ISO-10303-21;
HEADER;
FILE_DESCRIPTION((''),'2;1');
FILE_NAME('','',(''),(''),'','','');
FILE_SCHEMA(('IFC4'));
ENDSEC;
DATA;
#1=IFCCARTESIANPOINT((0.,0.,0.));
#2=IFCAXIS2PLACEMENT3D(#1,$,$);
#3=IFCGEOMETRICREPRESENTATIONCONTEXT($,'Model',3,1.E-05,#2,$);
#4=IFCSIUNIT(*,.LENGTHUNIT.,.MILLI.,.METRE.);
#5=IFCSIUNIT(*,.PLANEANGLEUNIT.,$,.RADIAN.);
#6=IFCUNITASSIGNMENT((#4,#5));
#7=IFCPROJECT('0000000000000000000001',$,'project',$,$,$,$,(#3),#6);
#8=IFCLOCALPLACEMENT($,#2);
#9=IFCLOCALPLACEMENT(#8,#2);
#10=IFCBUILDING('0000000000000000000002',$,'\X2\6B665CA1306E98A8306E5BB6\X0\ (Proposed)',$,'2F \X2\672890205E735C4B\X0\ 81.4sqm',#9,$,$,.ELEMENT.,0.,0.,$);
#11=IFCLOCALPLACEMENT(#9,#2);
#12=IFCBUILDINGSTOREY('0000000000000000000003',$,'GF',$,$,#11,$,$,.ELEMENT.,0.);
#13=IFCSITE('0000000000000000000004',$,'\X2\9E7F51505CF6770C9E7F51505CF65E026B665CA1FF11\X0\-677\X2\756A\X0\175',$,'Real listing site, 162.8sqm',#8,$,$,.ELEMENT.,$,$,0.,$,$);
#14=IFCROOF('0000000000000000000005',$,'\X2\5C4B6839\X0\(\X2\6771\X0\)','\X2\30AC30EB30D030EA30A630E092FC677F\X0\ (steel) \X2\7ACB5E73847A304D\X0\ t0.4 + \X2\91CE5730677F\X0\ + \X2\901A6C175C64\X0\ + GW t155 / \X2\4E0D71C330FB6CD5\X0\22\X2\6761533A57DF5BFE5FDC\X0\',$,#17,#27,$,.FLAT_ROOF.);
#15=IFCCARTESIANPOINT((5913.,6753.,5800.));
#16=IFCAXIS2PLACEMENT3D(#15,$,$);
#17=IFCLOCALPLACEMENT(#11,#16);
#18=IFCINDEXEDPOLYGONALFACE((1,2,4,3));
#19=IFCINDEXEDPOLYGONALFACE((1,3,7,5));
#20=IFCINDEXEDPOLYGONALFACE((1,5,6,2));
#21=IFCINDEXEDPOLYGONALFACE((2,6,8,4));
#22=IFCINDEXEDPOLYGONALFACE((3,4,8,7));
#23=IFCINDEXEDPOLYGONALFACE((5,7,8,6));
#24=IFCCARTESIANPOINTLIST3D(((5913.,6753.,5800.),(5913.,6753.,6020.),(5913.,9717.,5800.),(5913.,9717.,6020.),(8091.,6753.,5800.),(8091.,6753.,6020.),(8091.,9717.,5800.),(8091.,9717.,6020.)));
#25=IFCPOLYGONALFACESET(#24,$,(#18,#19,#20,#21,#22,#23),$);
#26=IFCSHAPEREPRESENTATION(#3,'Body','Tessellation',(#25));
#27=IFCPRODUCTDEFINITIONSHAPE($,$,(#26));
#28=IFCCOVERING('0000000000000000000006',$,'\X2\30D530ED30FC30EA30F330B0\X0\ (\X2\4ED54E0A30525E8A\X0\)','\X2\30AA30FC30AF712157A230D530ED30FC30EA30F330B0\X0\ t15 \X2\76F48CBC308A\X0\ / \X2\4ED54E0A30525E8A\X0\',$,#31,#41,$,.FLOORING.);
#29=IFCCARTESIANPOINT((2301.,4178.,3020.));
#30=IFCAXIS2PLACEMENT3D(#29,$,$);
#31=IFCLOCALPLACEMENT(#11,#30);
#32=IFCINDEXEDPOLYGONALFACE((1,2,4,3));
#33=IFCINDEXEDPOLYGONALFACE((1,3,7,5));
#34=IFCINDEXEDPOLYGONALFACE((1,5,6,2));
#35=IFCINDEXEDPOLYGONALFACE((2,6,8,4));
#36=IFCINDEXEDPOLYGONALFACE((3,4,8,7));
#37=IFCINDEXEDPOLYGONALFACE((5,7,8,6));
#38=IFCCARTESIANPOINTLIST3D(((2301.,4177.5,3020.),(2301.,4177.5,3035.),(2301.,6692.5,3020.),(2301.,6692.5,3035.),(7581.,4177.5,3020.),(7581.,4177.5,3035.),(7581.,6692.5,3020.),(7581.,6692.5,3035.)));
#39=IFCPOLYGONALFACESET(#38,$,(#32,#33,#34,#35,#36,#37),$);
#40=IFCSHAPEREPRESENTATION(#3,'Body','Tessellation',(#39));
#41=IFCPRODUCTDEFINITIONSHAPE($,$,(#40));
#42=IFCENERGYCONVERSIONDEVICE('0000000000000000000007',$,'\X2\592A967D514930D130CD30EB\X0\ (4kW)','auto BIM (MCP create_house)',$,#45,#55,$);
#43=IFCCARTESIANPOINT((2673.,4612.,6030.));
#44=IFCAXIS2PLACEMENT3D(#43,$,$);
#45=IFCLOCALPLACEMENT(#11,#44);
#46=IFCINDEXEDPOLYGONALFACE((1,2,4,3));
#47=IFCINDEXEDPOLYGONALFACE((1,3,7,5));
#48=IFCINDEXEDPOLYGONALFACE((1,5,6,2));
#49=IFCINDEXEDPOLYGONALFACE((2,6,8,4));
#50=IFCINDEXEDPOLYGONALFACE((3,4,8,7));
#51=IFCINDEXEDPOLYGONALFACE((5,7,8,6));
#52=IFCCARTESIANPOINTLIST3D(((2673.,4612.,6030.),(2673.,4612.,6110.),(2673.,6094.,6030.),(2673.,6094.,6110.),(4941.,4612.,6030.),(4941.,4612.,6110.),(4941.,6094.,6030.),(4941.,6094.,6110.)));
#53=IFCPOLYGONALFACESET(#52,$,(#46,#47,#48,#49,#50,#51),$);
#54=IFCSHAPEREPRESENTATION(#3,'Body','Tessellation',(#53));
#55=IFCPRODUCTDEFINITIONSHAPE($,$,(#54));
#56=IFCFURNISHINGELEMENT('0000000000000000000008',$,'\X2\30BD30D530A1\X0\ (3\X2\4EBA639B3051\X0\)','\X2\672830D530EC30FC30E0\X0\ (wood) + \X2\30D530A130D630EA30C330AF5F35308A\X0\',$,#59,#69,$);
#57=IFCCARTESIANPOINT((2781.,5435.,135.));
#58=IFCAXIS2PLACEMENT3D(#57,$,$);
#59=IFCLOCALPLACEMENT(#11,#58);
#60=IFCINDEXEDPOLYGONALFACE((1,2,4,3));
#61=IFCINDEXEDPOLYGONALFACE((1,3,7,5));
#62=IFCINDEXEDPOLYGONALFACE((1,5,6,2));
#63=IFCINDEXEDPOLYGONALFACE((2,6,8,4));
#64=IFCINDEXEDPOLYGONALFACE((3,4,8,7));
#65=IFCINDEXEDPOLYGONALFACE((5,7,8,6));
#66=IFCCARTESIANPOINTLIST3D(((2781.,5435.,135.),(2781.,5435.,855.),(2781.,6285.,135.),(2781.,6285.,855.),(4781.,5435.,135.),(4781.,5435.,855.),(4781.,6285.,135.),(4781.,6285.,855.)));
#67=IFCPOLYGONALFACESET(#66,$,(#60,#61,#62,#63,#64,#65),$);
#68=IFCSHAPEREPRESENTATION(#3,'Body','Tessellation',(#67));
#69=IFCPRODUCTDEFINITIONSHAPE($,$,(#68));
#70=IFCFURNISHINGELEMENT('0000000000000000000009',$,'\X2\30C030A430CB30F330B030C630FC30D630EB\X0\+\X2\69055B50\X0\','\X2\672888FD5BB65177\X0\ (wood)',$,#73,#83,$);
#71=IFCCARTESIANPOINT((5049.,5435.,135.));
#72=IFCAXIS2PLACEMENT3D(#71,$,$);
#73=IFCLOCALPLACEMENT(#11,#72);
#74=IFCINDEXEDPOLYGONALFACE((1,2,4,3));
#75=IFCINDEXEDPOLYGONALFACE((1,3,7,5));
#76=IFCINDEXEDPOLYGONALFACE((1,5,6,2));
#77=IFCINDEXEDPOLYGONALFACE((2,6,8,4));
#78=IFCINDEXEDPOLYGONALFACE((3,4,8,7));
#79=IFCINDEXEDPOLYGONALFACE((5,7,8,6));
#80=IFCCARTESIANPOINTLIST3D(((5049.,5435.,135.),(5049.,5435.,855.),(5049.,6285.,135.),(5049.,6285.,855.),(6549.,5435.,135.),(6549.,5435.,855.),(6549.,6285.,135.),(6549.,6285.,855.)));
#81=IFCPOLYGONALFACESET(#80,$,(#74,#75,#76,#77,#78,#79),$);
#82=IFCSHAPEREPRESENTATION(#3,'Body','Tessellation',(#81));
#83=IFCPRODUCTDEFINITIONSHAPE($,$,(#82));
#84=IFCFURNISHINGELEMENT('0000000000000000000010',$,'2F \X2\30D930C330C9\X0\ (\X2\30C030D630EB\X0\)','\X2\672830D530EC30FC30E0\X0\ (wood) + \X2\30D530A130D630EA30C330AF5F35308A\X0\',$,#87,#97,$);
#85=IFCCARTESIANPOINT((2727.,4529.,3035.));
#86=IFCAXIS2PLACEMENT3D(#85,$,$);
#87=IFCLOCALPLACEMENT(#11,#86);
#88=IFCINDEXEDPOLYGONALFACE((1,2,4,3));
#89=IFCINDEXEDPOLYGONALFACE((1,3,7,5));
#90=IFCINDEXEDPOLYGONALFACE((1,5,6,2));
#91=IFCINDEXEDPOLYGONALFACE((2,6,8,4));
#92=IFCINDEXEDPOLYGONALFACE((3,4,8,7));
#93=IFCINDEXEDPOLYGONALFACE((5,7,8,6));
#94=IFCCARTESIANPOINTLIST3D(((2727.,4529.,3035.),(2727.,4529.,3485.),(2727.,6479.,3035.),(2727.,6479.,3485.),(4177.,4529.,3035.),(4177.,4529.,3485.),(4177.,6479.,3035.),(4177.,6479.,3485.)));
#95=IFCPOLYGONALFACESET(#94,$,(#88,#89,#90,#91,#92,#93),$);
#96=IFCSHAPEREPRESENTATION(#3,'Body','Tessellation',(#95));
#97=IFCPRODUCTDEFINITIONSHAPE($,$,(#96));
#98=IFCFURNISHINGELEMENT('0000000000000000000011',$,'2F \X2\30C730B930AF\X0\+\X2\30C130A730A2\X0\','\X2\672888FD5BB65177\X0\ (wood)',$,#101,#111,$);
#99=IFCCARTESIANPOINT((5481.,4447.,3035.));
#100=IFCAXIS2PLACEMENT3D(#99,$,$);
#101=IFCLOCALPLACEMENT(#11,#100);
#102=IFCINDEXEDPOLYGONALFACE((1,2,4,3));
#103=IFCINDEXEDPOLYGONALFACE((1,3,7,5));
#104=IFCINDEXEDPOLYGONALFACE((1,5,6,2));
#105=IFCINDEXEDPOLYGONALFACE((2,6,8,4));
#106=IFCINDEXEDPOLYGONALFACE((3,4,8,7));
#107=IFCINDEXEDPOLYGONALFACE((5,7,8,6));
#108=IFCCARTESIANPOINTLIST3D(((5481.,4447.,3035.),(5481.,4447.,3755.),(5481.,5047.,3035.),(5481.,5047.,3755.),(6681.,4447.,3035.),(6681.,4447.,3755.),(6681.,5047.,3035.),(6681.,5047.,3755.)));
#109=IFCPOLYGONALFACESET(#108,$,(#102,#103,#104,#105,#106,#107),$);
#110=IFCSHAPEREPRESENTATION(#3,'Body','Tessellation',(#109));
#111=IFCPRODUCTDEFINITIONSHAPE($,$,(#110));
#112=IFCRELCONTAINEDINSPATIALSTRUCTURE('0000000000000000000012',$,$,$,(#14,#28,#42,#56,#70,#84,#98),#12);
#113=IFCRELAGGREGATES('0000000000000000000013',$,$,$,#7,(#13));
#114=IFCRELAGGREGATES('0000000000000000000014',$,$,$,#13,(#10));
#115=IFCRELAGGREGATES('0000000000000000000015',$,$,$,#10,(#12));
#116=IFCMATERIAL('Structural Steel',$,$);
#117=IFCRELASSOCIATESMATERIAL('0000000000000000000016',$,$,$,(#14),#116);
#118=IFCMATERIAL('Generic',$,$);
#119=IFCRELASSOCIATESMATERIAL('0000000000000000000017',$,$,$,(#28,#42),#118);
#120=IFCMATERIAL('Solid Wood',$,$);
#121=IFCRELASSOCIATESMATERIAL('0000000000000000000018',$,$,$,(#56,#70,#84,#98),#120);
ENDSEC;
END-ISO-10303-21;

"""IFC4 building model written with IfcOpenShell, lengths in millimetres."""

from ifc_helpers import new_model, si_unit, frame, frame_2d, origin, place, context, project, spatial, rectangle, extrude, material, element, save


model = new_model("IFC4")

# Units and contexts
model_context = context("Model", 3, precision=1e-05, world=origin())
ifc_project = project(units=[si_unit("LENGTHUNIT", "METRE", prefix="MILLI"), si_unit("PLANEANGLEUNIT", "RADIAN")], contexts=[model_context])

# Site, building, storey
site_placement = place(None, origin())
site = spatial("IfcSite", under=ifc_project, at=site_placement, Name="鹿児島県鹿児島市武岡１-677番175", ObjectType="Real listing site, 162.8sqm", CompositionType="ELEMENT", RefElevation=0.0)
building_placement = place(site_placement, origin())
building = spatial("IfcBuilding", under=site, at=building_placement, Name="武岡の風の家 (Proposed)", ObjectType="2F 木造平屋 81.4sqm", CompositionType="ELEMENT", ElevationOfRefHeight=0.0, ElevationOfTerrain=0.0)
storey_placement = place(building_placement, origin())
storey = spatial("IfcBuildingStorey", under=building, at=storey_placement, Name="GF", CompositionType="ELEMENT", Elevation=0.0)

# Shared definitions
ifc_material_1 = material(Name="Solid Wood")

# Roof
ifc_material_2 = material(Name="Structural Steel")
roof_1_placement = place(storey_placement, frame((5913.0, 6753.0, 5800.0)))
element("IfcRoof", 1, at=roof_1_placement, inside=storey, material=ifc_material_2, Name="屋根(東)", Description="ガルバリウム鋼板 (steel) 立平葺き t0.4 + 野地板 + 通気層 + GW t155 / 不燃・法22条区域対応", PredefinedType="FLAT_ROOF", context=model_context, shape_type="SweptSolid", body=[
    extrude(rectangle(XDim=2178.0, YDim=2964.0, at=frame_2d((1089.0, 1482.0))), frame((5913.0, 6753.0, 5800.0)), (0.0, 0.0, 1.0), 220.0),
])

# Covering
ifc_material_3 = material(Name="Generic")
covering_placement = place(storey_placement, frame((2301.0, 4178.0, 3020.0)))
element("IfcCovering", 2, at=covering_placement, inside=storey, material=ifc_material_3, Name="フローリング (仕上げ床)", Description="オーク無垢フローリング t15 直貼り / 仕上げ床", PredefinedType="FLOORING", context=model_context, shape_type="SweptSolid", body=[
    extrude(rectangle(XDim=5280.0, YDim=2515.0, at=frame_2d((2640.0, 1257.0))), frame((2301.0, 4178.0, 3020.0)), (0.0, 0.0, 1.0), 15.0),
])

# Energy conversion device
energy_conversion_device_placement = place(storey_placement, frame((2673.0, 4612.0, 6030.0)))
element("IfcEnergyConversionDevice", 3, at=energy_conversion_device_placement, inside=storey, material=ifc_material_3, Name="太陽光パネル (4kW)", Description="auto BIM (MCP create_house)", context=model_context, shape_type="SweptSolid", body=[
    extrude(rectangle(XDim=2268.0, YDim=1482.0, at=frame_2d((1134.0, 741.0))), frame((2673.0, 4612.0, 6030.0)), (0.0, 0.0, 1.0), 80.0),
])

# Furnishing elements
furnishing_1_placement = place(storey_placement, frame((2781.0, 5435.0, 135.0)))
element("IfcFurnishingElement", 4, at=furnishing_1_placement, inside=storey, material=ifc_material_1, Name="ソファ (3人掛け)", Description="木フレーム (wood) + ファブリック張り", context=model_context, shape_type="SweptSolid", body=[
    extrude(rectangle(XDim=2000.0, YDim=850.0, at=frame_2d((1000.0, 425.0))), frame((2781.0, 5435.0, 135.0)), (0.0, 0.0, 1.0), 720.0),
])
furnishing_2_placement = place(storey_placement, frame((5049.0, 5435.0, 135.0)))
element("IfcFurnishingElement", 5, at=furnishing_2_placement, inside=storey, material=ifc_material_1, Name="ダイニングテーブル+椅子", Description="木製家具 (wood)", context=model_context, shape_type="SweptSolid", body=[
    extrude(rectangle(XDim=1500.0, YDim=850.0, at=frame_2d((750.0, 425.0))), frame((5049.0, 5435.0, 135.0)), (0.0, 0.0, 1.0), 720.0),
])
furnishing_3_placement = place(storey_placement, frame((2727.0, 4529.0, 3035.0)))
element("IfcFurnishingElement", 6, at=furnishing_3_placement, inside=storey, material=ifc_material_1, Name="2F ベッド (ダブル)", Description="木フレーム (wood) + ファブリック張り", context=model_context, shape_type="SweptSolid", body=[
    extrude(rectangle(XDim=1450.0, YDim=1950.0, at=frame_2d((725.0, 975.0))), frame((2727.0, 4529.0, 3035.0)), (0.0, 0.0, 1.0), 450.0),
])
furnishing_4_placement = place(storey_placement, frame((5481.0, 4447.0, 3035.0)))
element("IfcFurnishingElement", 7, at=furnishing_4_placement, inside=storey, material=ifc_material_1, Name="2F デスク+チェア", Description="木製家具 (wood)", context=model_context, shape_type="SweptSolid", body=[
    extrude(rectangle(XDim=1200.0, YDim=600.0, at=frame_2d((600.0, 300.0))), frame((5481.0, 4447.0, 3035.0)), (0.0, 0.0, 1.0), 720.0),
])

save(model, "model.ifc")
